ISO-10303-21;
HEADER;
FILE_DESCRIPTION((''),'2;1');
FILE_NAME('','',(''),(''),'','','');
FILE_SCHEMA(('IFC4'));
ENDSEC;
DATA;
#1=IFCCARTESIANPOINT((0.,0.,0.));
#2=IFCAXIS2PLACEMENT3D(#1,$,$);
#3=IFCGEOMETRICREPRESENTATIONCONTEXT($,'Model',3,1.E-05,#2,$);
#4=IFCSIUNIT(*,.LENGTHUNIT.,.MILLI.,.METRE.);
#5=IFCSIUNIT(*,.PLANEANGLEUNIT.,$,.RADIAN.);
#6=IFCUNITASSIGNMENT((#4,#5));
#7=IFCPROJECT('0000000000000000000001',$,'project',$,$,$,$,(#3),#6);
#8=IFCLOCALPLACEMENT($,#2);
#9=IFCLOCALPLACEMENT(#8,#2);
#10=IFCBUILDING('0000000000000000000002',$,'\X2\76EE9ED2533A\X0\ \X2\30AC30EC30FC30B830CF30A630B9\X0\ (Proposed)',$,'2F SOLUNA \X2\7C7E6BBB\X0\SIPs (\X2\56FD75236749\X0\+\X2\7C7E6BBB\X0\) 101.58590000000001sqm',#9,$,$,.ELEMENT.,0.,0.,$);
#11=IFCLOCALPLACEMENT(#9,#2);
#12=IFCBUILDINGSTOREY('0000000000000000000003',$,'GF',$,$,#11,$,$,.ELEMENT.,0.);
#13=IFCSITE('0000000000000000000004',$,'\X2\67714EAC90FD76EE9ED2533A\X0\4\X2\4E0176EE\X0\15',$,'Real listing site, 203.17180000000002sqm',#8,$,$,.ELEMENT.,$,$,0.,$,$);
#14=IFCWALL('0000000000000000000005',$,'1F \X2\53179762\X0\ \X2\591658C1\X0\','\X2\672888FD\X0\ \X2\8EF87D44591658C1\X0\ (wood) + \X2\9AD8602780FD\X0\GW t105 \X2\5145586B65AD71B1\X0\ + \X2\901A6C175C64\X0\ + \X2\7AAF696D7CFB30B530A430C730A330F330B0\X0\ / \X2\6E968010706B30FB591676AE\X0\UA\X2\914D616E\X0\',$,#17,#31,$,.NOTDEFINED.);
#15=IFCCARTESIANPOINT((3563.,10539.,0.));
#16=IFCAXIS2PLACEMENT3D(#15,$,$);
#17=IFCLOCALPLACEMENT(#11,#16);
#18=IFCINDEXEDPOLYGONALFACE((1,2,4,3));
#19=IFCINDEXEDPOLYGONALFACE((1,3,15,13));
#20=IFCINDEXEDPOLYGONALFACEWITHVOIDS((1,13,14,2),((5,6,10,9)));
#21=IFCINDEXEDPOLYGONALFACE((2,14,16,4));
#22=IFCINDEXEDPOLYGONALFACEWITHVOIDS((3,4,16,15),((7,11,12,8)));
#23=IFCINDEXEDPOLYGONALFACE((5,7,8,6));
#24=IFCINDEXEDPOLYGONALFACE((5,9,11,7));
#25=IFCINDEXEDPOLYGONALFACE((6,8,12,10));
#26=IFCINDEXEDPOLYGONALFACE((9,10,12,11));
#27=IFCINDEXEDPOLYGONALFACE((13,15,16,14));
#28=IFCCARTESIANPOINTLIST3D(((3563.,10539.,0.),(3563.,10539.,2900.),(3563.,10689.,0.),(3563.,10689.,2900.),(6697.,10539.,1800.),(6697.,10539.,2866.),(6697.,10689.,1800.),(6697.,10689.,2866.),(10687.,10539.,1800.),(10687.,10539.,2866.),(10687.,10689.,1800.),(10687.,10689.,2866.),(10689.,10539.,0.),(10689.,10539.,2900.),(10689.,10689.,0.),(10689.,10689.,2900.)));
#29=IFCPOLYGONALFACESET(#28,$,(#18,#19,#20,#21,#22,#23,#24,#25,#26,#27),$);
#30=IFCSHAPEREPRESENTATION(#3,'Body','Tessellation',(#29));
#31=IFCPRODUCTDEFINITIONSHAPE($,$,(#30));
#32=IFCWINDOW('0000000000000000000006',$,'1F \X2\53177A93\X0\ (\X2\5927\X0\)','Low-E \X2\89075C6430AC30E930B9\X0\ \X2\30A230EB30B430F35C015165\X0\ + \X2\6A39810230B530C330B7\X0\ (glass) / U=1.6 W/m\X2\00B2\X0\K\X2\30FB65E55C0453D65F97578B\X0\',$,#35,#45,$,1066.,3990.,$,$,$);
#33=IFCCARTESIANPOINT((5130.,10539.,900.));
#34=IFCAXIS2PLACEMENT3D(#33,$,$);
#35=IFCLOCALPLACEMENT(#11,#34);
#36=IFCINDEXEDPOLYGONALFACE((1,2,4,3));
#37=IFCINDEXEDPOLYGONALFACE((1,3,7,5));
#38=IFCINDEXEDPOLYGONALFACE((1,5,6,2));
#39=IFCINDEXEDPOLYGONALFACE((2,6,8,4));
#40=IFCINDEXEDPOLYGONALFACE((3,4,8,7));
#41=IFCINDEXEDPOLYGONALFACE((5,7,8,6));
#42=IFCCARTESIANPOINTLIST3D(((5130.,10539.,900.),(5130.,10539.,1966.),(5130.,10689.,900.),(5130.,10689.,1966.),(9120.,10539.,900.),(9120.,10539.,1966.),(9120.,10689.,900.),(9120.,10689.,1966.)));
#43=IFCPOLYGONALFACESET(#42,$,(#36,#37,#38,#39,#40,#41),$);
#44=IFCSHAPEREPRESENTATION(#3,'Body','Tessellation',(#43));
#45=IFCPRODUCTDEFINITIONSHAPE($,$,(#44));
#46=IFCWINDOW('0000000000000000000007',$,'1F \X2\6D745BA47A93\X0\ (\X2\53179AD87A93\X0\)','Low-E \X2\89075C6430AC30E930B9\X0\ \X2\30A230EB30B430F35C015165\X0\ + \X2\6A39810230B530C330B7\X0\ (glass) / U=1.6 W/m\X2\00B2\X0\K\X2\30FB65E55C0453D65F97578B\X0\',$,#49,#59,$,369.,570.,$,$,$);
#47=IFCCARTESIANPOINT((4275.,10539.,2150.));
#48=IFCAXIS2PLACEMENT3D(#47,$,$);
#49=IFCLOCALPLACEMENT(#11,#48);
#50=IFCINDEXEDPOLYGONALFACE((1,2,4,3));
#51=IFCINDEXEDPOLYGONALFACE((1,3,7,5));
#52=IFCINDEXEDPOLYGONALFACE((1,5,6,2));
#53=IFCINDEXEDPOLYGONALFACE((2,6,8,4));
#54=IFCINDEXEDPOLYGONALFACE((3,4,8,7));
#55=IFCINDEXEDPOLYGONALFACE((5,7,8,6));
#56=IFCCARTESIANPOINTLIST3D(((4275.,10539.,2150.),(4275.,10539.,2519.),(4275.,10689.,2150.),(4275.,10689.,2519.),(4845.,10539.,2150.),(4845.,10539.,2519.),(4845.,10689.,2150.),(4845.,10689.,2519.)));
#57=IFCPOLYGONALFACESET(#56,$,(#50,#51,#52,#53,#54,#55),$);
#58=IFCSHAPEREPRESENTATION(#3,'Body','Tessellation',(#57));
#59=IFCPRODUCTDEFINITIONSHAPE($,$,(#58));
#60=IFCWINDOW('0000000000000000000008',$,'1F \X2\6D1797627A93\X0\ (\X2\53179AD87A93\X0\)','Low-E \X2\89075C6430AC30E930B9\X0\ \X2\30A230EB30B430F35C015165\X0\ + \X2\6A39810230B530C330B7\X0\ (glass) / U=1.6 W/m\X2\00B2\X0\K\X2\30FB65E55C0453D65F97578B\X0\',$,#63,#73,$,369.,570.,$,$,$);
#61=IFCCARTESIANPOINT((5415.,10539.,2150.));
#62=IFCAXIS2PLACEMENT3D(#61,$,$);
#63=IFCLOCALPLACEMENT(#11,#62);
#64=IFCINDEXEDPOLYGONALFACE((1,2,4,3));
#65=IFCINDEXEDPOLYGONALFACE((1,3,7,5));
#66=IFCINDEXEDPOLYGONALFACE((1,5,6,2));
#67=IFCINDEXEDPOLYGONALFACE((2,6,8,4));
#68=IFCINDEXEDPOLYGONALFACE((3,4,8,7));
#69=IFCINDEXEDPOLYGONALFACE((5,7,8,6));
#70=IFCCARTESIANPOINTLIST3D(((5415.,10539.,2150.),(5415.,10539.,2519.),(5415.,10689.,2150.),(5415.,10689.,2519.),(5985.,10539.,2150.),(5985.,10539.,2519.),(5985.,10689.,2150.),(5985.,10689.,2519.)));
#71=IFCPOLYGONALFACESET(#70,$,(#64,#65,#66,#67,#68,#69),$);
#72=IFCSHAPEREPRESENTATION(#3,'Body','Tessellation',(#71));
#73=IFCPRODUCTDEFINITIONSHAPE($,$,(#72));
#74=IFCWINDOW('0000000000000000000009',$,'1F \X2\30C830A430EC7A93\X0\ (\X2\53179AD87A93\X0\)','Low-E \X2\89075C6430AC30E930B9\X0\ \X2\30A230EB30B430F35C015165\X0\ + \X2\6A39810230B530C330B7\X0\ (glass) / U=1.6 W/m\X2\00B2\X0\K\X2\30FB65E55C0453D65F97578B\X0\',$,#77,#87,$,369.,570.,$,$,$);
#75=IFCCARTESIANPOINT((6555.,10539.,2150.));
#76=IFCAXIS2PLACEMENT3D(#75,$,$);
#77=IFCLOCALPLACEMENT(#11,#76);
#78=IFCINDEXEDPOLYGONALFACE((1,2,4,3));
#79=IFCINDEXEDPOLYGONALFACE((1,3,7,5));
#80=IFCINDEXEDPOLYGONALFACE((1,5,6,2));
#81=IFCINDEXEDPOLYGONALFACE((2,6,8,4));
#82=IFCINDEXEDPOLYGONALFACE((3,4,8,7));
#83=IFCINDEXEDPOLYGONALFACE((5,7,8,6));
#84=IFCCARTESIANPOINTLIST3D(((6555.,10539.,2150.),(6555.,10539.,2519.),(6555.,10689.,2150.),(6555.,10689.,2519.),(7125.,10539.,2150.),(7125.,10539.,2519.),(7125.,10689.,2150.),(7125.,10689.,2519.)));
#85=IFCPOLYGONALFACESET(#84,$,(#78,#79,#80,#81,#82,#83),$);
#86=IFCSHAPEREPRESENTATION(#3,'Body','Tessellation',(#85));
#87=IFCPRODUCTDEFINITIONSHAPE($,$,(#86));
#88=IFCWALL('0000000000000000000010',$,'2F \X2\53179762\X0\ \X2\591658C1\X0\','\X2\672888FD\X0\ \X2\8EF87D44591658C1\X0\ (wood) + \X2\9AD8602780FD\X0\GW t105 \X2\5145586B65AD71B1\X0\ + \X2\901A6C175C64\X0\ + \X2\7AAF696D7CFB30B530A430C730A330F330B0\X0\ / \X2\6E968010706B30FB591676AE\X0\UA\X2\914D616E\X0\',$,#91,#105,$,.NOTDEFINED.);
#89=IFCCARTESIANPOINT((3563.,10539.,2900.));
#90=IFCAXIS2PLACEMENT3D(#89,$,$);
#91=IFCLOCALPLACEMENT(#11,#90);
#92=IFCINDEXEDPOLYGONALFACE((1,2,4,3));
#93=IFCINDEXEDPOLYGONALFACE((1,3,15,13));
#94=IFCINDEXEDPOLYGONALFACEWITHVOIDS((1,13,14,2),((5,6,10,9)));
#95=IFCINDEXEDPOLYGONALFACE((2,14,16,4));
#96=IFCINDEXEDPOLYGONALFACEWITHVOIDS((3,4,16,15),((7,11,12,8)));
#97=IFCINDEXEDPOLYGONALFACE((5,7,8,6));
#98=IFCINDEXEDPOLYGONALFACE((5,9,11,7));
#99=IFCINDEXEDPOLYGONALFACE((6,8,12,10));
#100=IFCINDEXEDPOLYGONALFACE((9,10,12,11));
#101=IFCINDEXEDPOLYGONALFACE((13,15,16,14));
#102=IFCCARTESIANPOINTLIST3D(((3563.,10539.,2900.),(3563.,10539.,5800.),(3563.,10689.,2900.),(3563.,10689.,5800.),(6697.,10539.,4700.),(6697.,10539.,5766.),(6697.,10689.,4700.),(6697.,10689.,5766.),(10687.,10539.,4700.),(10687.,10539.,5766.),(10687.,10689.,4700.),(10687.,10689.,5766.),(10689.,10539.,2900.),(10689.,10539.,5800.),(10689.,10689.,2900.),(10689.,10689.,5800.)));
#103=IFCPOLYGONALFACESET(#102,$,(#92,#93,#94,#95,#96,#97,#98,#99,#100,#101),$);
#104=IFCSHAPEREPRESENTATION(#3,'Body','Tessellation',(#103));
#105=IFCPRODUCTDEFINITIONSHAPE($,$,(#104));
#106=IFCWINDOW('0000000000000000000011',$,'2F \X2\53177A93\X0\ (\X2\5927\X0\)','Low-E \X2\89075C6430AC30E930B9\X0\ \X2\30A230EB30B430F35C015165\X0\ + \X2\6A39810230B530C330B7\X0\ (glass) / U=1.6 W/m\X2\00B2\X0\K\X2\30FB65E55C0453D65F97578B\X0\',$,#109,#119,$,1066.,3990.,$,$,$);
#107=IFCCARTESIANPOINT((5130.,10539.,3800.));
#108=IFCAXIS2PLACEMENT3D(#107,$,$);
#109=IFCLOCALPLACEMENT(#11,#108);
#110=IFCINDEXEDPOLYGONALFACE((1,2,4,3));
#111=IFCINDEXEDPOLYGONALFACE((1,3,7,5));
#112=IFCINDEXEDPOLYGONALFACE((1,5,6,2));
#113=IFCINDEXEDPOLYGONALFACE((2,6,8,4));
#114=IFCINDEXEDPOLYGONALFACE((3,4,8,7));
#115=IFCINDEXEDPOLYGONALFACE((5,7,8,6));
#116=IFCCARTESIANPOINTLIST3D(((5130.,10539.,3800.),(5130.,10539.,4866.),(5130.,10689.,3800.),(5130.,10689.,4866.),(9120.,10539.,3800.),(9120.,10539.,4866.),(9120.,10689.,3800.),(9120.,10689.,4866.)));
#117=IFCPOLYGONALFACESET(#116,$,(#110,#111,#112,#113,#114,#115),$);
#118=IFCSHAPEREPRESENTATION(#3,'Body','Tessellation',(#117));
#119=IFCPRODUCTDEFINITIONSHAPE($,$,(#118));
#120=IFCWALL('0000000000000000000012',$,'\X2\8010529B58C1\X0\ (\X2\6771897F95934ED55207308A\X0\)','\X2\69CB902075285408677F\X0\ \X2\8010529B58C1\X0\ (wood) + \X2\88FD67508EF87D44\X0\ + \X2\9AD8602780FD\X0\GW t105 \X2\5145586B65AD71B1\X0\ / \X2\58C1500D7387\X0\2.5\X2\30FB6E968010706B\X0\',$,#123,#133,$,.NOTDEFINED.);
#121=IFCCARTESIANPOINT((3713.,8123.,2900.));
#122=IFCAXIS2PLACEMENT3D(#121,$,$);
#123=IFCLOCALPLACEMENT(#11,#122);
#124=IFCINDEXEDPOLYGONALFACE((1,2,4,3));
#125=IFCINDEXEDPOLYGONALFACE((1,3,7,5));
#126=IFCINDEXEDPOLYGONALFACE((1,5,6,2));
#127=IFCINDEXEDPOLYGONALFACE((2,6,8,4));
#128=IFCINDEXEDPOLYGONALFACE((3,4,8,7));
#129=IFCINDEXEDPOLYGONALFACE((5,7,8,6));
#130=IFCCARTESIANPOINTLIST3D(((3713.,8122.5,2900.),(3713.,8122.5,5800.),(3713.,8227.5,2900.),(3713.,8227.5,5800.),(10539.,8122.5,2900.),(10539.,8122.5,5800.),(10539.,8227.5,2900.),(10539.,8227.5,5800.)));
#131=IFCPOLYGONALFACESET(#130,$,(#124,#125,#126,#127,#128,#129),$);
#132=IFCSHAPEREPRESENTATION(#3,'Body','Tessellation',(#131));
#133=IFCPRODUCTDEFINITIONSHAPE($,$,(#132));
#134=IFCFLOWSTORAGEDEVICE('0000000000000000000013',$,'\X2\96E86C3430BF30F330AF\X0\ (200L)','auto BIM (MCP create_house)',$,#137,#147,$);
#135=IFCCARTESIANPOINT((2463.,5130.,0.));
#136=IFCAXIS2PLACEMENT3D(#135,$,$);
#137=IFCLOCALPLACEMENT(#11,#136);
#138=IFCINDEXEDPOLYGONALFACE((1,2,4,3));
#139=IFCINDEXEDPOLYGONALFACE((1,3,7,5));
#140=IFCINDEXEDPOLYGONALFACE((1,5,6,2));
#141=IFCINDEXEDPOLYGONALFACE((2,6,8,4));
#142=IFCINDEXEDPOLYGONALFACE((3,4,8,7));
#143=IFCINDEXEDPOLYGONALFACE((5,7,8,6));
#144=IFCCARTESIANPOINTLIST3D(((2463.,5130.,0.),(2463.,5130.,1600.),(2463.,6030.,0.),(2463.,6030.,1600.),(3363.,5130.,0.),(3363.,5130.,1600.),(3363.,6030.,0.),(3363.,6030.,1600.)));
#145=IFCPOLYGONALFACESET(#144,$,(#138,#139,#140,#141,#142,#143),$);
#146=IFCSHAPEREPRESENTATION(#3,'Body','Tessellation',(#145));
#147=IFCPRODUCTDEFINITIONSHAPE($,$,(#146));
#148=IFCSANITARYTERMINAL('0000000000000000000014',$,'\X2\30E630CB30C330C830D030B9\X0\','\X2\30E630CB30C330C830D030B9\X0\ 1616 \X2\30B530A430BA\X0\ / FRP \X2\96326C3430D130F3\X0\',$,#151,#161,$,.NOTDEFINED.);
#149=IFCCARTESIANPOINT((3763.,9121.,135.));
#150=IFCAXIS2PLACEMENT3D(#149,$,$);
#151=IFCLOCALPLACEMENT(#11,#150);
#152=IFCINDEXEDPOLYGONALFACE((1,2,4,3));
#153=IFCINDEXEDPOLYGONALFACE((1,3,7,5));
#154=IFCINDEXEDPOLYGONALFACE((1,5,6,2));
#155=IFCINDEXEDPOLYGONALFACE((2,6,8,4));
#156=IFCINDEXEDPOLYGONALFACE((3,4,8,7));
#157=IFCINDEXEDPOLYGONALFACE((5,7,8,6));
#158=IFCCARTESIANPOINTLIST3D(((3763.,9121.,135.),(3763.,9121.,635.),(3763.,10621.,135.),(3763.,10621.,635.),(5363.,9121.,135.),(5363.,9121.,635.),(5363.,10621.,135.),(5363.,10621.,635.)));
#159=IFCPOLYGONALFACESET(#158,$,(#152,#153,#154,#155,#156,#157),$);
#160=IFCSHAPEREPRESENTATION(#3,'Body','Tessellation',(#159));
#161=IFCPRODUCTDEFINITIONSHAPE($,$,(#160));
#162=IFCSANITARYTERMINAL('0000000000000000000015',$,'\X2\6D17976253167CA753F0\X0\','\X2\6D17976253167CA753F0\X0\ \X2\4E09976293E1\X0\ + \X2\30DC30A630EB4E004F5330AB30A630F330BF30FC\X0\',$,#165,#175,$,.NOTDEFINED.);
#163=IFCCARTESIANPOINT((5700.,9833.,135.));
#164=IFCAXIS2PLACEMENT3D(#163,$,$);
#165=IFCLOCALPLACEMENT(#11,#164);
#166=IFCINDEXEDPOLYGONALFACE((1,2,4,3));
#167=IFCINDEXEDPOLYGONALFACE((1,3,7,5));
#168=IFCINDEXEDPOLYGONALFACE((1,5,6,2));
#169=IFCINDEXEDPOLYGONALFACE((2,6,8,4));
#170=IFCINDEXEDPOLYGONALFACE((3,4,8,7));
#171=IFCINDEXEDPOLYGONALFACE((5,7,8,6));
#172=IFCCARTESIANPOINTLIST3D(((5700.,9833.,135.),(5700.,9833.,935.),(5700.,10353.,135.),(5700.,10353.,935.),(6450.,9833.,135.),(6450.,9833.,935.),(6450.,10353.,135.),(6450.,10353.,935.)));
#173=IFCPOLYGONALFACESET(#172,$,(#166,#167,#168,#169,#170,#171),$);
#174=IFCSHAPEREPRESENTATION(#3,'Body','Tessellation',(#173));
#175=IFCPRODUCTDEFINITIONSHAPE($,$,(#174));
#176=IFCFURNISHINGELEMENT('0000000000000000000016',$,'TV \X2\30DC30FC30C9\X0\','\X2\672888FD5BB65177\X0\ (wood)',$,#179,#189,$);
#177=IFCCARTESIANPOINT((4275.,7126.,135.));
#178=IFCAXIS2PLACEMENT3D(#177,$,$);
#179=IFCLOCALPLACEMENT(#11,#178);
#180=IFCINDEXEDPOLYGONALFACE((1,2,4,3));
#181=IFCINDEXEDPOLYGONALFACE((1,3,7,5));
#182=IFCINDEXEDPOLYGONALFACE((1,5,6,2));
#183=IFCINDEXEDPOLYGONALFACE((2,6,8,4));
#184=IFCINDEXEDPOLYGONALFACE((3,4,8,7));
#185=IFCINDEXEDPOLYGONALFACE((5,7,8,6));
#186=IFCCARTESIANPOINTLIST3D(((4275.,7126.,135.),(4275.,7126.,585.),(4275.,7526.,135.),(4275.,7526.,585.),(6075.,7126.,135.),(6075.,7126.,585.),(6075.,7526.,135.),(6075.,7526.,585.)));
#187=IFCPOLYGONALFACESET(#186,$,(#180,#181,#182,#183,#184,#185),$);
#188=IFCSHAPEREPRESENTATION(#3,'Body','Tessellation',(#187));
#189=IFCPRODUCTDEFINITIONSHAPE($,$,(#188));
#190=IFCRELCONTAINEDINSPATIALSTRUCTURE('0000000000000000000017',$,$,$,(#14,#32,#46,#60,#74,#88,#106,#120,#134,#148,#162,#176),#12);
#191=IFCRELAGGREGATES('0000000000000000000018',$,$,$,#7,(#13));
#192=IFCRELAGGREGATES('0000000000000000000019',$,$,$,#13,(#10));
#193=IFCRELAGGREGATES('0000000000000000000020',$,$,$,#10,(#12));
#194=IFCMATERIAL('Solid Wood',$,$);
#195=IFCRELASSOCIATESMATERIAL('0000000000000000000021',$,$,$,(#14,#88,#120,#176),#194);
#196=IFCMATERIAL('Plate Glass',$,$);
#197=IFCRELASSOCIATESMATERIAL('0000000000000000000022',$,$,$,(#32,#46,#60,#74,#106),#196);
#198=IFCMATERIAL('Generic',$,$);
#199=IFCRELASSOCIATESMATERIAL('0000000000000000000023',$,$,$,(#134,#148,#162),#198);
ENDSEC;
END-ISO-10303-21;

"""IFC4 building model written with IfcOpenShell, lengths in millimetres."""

from ifc_helpers import new_model, si_unit, frame, frame_2d, origin, place, context, project, spatial, rectangle, extrude, material, element, fill, save


model = new_model("IFC4")

# Units and contexts
model_context = context("Model", 3, precision=1e-05, world=origin())
ifc_project = project(units=[si_unit("LENGTHUNIT", "METRE", prefix="MILLI"), si_unit("PLANEANGLEUNIT", "RADIAN")], contexts=[model_context])

# Site, building, storey
site_placement = place(None, origin())
site = spatial("IfcSite", under=ifc_project, at=site_placement, Name="東京都目黒区4丁目15", ObjectType="Real listing site, 203.17180000000002sqm", CompositionType="ELEMENT", RefElevation=0.0)
building_placement = place(site_placement, origin())
building = spatial("IfcBuilding", under=site, at=building_placement, Name="目黒区 ガレージハウス (Proposed)", ObjectType="2F SOLUNA 籾殻SIPs (国産杉+籾殻) 101.58590000000001sqm", CompositionType="ELEMENT", ElevationOfRefHeight=0.0, ElevationOfTerrain=0.0)
storey_placement = place(building_placement, origin())
storey = spatial("IfcBuildingStorey", under=building, at=storey_placement, Name="GF", CompositionType="ELEMENT", Elevation=0.0)

# Wall, openings, windows
ifc_material_1 = material(Name="Solid Wood")
wall_1_placement = place(storey_placement, frame((3563.0, 10539.0, 0.0)))
wall_1 = element("IfcWall", 1, at=wall_1_placement, inside=storey, material=ifc_material_1, Name="1F 北面 外壁", Description="木製 軸組外壁 (wood) + 高性能GW t105 充填断熱 + 通気層 + 窯業系サイディング / 準耐火・外皮UA配慮", PredefinedType="NOTDEFINED", context=model_context, shape_type="SweptSolid", body=[
    extrude(rectangle(XDim=7126.0, YDim=150.0, at=frame_2d((3563.0, 75.0))), frame((3563.0, 10539.0, 0.0)), (0.0, 0.0, 1.0), 2900.0),
])
opening_1_placement = place(storey_placement, frame((5130.0, 10539.0, 900.0)))
opening_1 = element("IfcOpeningElement", 2, at=opening_1_placement, cuts=wall_1, PredefinedType="NOTDEFINED", context=model_context, shape_type="SweptSolid", body=[
    extrude(rectangle(XDim=3990.0, YDim=150.0, at=frame_2d((1995.0, 75.0))), frame((5130.0, 10539.0, 900.0)), (0.0, 0.0, 1.0), 1066.0),
])
opening_2_placement = place(storey_placement, frame((4275.0, 10539.0, 2150.0)))
opening_2 = element("IfcOpeningElement", 3, at=opening_2_placement, cuts=wall_1, PredefinedType="NOTDEFINED", context=model_context, shape_type="SweptSolid", body=[
    extrude(rectangle(XDim=570.0, YDim=150.0, at=frame_2d((285.0, 75.0))), frame((4275.0, 10539.0, 2150.0)), (0.0, 0.0, 1.0), 369.0),
])
opening_3_placement = place(storey_placement, frame((5415.0, 10539.0, 2150.0)))
opening_3 = element("IfcOpeningElement", 4, at=opening_3_placement, cuts=wall_1, PredefinedType="NOTDEFINED", context=model_context, shape_type="SweptSolid", body=[
    extrude(rectangle(XDim=570.0, YDim=150.0, at=frame_2d((285.0, 75.0))), frame((5415.0, 10539.0, 2150.0)), (0.0, 0.0, 1.0), 369.0),
])
opening_4_placement = place(storey_placement, frame((6555.0, 10539.0, 2150.0)))
opening_4 = element("IfcOpeningElement", 5, at=opening_4_placement, cuts=wall_1, PredefinedType="NOTDEFINED", context=model_context, shape_type="SweptSolid", body=[
    extrude(rectangle(XDim=570.0, YDim=150.0, at=frame_2d((285.0, 75.0))), frame((6555.0, 10539.0, 2150.0)), (0.0, 0.0, 1.0), 369.0),
])
ifc_material_2 = material(Name="Plate Glass")
window_1_placement = place(storey_placement, frame((5130.0, 10539.0, 900.0)))
window_1 = element("IfcWindow", 6, at=window_1_placement, inside=storey, material=ifc_material_2, Name="1F 北窓 (大)", Description="Low-E 複層ガラス アルゴン封入 + 樹脂サッシ (glass) / U=1.6 W/m²K・日射取得型", OverallHeight=1066.0, OverallWidth=3990.0, context=model_context, shape_type="SweptSolid", body=[
    extrude(rectangle(XDim=3990.0, YDim=150.0, at=frame_2d((1995.0, 75.0))), frame((5130.0, 10539.0, 900.0)), (0.0, 0.0, 1.0), 1066.0),
])
fill(opening_1, window_1)
window_2_placement = place(storey_placement, frame((4275.0, 10539.0, 2150.0)))
window_2 = element("IfcWindow", 7, at=window_2_placement, inside=storey, material=ifc_material_2, Name="1F 浴室窓 (北高窓)", Description="Low-E 複層ガラス アルゴン封入 + 樹脂サッシ (glass) / U=1.6 W/m²K・日射取得型", OverallHeight=369.0, OverallWidth=570.0, context=model_context, shape_type="SweptSolid", body=[
    extrude(rectangle(XDim=570.0, YDim=150.0, at=frame_2d((285.0, 75.0))), frame((4275.0, 10539.0, 2150.0)), (0.0, 0.0, 1.0), 369.0),
])
fill(opening_2, window_2)
window_3_placement = place(storey_placement, frame((5415.0, 10539.0, 2150.0)))
window_3 = element("IfcWindow", 8, at=window_3_placement, inside=storey, material=ifc_material_2, Name="1F 洗面窓 (北高窓)", Description="Low-E 複層ガラス アルゴン封入 + 樹脂サッシ (glass) / U=1.6 W/m²K・日射取得型", OverallHeight=369.0, OverallWidth=570.0, context=model_context, shape_type="SweptSolid", body=[
    extrude(rectangle(XDim=570.0, YDim=150.0, at=frame_2d((285.0, 75.0))), frame((5415.0, 10539.0, 2150.0)), (0.0, 0.0, 1.0), 369.0),
])
fill(opening_3, window_3)
window_4_placement = place(storey_placement, frame((6555.0, 10539.0, 2150.0)))
window_4 = element("IfcWindow", 9, at=window_4_placement, inside=storey, material=ifc_material_2, Name="1F トイレ窓 (北高窓)", Description="Low-E 複層ガラス アルゴン封入 + 樹脂サッシ (glass) / U=1.6 W/m²K・日射取得型", OverallHeight=369.0, OverallWidth=570.0, context=model_context, shape_type="SweptSolid", body=[
    extrude(rectangle(XDim=570.0, YDim=150.0, at=frame_2d((285.0, 75.0))), frame((6555.0, 10539.0, 2150.0)), (0.0, 0.0, 1.0), 369.0),
])
fill(opening_4, window_4)

# Wall, opening, window
wall_2_placement = place(storey_placement, frame((3563.0, 10539.0, 2900.0)))
wall_2 = element("IfcWall", 10, at=wall_2_placement, inside=storey, material=ifc_material_1, Name="2F 北面 外壁", Description="木製 軸組外壁 (wood) + 高性能GW t105 充填断熱 + 通気層 + 窯業系サイディング / 準耐火・外皮UA配慮", PredefinedType="NOTDEFINED", context=model_context, shape_type="SweptSolid", body=[
    extrude(rectangle(XDim=7126.0, YDim=150.0, at=frame_2d((3563.0, 75.0))), frame((3563.0, 10539.0, 2900.0)), (0.0, 0.0, 1.0), 2900.0),
])
opening_5_placement = place(storey_placement, frame((5130.0, 10539.0, 3800.0)))
opening_5 = element("IfcOpeningElement", 11, at=opening_5_placement, cuts=wall_2, PredefinedType="NOTDEFINED", context=model_context, shape_type="SweptSolid", body=[
    extrude(rectangle(XDim=3990.0, YDim=150.0, at=frame_2d((1995.0, 75.0))), frame((5130.0, 10539.0, 3800.0)), (0.0, 0.0, 1.0), 1066.0),
])
window_5_placement = place(storey_placement, frame((5130.0, 10539.0, 3800.0)))
window_5 = element("IfcWindow", 12, at=window_5_placement, inside=storey, material=ifc_material_2, Name="2F 北窓 (大)", Description="Low-E 複層ガラス アルゴン封入 + 樹脂サッシ (glass) / U=1.6 W/m²K・日射取得型", OverallHeight=1066.0, OverallWidth=3990.0, context=model_context, shape_type="SweptSolid", body=[
    extrude(rectangle(XDim=3990.0, YDim=150.0, at=frame_2d((1995.0, 75.0))), frame((5130.0, 10539.0, 3800.0)), (0.0, 0.0, 1.0), 1066.0),
])
fill(opening_5, window_5)

# Wall
wall_3_placement = place(storey_placement, frame((3713.0, 8123.0, 2900.0)))
element("IfcWall", 13, at=wall_3_placement, inside=storey, material=ifc_material_1, Name="耐力壁 (東西間仕切り)", Description="構造用合板 耐力壁 (wood) + 製材軸組 + 高性能GW t105 充填断熱 / 壁倍率2.5・準耐火", PredefinedType="NOTDEFINED", context=model_context, shape_type="SweptSolid", body=[
    extrude(rectangle(XDim=6826.0, YDim=105.0, at=frame_2d((3413.0, 52.0))), frame((3713.0, 8123.0, 2900.0)), (0.0, 0.0, 1.0), 2900.0),
])

# Flow storage device
ifc_material_3 = material(Name="Generic")
flow_storage_device_placement = place(storey_placement, frame((2463.0, 5130.0, 0.0)))
element("IfcFlowStorageDevice", 14, at=flow_storage_device_placement, inside=storey, material=ifc_material_3, Name="雨水タンク (200L)", Description="auto BIM (MCP create_house)", context=model_context, shape_type="SweptSolid", body=[
    extrude(rectangle(XDim=900.0, YDim=900.0, at=frame_2d((450.0, 450.0))), frame((2463.0, 5130.0, 0.0)), (0.0, 0.0, 1.0), 1600.0),
])

# Sanitary terminals
sanitary_terminal_1_placement = place(storey_placement, frame((3763.0, 9121.0, 135.0)))
element("IfcSanitaryTerminal", 15, at=sanitary_terminal_1_placement, inside=storey, material=ifc_material_3, Name="ユニットバス", Description="ユニットバス 1616 サイズ / FRP 防水パン", PredefinedType="NOTDEFINED", context=model_context, shape_type="SweptSolid", body=[
    extrude(rectangle(XDim=1600.0, YDim=1500.0, at=frame_2d((800.0, 750.0))), frame((3763.0, 9121.0, 135.0)), (0.0, 0.0, 1.0), 500.0),
])
sanitary_terminal_2_placement = place(storey_placement, frame((5700.0, 9833.0, 135.0)))
element("IfcSanitaryTerminal", 16, at=sanitary_terminal_2_placement, inside=storey, material=ifc_material_3, Name="洗面化粧台", Description="洗面化粧台 三面鏡 + ボウル一体カウンター", PredefinedType="NOTDEFINED", context=model_context, shape_type="SweptSolid", body=[
    extrude(rectangle(XDim=750.0, YDim=520.0, at=frame_2d((375.0, 260.0))), frame((5700.0, 9833.0, 135.0)), (0.0, 0.0, 1.0), 800.0),
])

# Furnishing element
furnishing_1_placement = place(storey_placement, frame((4275.0, 7126.0, 135.0)))
element("IfcFurnishingElement", 17, at=furnishing_1_placement, inside=storey, material=ifc_material_1, Name="TV ボード", Description="木製家具 (wood)", context=model_context, shape_type="SweptSolid", body=[
    extrude(rectangle(XDim=1800.0, YDim=400.0, at=frame_2d((900.0, 200.0))), frame((4275.0, 7126.0, 135.0)), (0.0, 0.0, 1.0), 450.0),
])

save(model, "model.ifc")
